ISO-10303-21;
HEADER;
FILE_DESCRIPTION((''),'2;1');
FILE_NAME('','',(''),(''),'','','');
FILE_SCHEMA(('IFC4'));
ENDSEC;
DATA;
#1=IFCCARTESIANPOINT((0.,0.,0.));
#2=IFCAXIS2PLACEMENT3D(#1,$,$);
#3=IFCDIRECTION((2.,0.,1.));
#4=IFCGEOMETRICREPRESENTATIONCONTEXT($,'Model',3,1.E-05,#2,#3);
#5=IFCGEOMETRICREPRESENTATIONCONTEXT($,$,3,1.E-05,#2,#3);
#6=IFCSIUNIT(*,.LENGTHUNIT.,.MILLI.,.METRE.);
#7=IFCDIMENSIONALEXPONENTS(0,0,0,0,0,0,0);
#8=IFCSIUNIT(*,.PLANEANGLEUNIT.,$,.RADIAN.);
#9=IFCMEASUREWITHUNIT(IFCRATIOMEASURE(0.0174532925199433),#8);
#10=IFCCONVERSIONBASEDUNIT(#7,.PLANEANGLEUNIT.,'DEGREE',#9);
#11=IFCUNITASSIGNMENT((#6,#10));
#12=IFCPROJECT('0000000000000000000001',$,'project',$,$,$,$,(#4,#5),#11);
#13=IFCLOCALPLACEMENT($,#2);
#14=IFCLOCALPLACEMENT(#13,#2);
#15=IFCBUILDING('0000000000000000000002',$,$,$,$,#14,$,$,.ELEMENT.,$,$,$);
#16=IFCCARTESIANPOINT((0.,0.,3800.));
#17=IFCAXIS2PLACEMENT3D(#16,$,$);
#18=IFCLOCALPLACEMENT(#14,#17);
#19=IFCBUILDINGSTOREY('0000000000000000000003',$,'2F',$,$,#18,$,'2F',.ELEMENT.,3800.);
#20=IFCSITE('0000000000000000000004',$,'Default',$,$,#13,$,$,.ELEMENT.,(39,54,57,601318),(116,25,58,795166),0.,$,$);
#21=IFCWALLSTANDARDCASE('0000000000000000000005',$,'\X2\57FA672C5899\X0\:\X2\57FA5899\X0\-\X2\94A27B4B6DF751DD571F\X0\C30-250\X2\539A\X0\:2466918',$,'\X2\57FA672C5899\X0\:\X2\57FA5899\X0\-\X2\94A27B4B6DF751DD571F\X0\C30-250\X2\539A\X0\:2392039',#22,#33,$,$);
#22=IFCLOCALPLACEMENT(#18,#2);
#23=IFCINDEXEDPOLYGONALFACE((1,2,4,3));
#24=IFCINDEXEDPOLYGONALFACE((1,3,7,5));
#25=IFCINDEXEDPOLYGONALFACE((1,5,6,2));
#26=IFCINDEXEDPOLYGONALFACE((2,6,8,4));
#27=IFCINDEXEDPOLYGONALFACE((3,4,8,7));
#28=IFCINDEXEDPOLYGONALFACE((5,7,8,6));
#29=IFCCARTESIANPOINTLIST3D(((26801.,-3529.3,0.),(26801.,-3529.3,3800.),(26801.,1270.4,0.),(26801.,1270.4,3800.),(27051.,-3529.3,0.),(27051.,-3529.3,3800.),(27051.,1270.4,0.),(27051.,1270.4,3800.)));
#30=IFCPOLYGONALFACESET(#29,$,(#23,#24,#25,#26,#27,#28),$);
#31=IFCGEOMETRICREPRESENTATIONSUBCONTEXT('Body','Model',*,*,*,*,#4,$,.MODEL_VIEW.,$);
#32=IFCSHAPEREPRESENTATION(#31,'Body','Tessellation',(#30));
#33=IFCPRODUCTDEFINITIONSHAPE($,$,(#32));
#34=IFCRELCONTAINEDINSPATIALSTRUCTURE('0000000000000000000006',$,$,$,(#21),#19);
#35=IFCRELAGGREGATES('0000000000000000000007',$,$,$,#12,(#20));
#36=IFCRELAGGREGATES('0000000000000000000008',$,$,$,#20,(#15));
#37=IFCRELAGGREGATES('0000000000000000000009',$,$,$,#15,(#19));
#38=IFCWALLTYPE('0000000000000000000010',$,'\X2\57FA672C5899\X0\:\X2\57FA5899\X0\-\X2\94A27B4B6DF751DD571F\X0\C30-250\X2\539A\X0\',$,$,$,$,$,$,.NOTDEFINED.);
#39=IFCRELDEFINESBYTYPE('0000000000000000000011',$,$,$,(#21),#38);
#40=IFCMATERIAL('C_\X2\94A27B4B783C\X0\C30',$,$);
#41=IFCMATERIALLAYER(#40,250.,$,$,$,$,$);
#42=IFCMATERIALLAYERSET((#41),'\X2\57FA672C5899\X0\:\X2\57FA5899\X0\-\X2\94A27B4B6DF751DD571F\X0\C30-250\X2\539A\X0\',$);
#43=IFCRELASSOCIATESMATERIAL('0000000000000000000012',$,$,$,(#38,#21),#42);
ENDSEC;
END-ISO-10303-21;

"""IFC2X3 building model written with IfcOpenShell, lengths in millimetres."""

from ifc_helpers import new_model, entity, si_unit, converted_unit, direction, frame, frame_2d, origin, place, context, subcontext, project, spatial, polyline, rectangle, extrude, clip, bounded_halfspace, material, layer, layer_set, layer_usage, type_object, element, save


model = new_model("IFC2X3")

# Units and contexts
model_context = context("Model", 3, precision=1e-05, world=origin(), true_north=direction((2.0, 0.0, 1.0)))
context_of_model = context(None, 3, precision=1e-05, world=origin(), true_north=direction((2.0, 0.0, 1.0)))
body_context = subcontext(model_context, "Body", "Model", "MODEL_VIEW")
ifc_project = project(units=[si_unit("LENGTHUNIT", "METRE", prefix="MILLI"), converted_unit("PLANEANGLEUNIT", "DEGREE", entity("IfcRatioMeasure", 0.0174532925199433), si_unit("PLANEANGLEUNIT", "RADIAN"), dimensions=[0, 0, 0, 0, 0, 0, 0])], contexts=[model_context, context_of_model])

# Site, building, storey
site_placement = place(None, origin())
site = spatial("IfcSite", under=ifc_project, at=site_placement, Name="Default", CompositionType="ELEMENT", RefLatitude=(39, 54, 57, 601318), RefLongitude=(116, 25, 58, 795166), RefElevation=0.0)
building_placement = place(site_placement, origin())
building = spatial("IfcBuilding", under=site, at=building_placement, CompositionType="ELEMENT")
storey_placement = place(building_placement, frame((0.0, 0.0, 3800.0)))
storey = spatial("IfcBuildingStorey", under=building, at=storey_placement, Name="2F", LongName="2F", CompositionType="ELEMENT", Elevation=3800.0)

# Shared definitions
ifc_material_1 = material(Name="C_钢筋砼C30")

# Wall
ifc_layer = layer(ifc_material_1, 250.0)
ifc_layer_set = layer_set([ifc_layer], Name="基本墙:基墙-钢筋混凝土C30-250厚")
wall_type = type_object("IfcWallType", Name="基本墙:基墙-钢筋混凝土C30-250厚", PredefinedType="NOTDEFINED", material=ifc_layer_set)
ifc_layer_usage_1 = layer_usage(ifc_layer_set, "AXIS2", "NEGATIVE", 125.0)
wall_1_placement = place(storey_placement, frame((26926.0, 1270.4, 0.0), z_axis=(0.0, 0.0, 1.0), x_axis=(0.0, -1.0, 0.0)))
element("IfcWallStandardCase", 1, at=wall_1_placement, inside=storey, type_object=wall_type, material=ifc_layer_usage_1, Name="基本墙:基墙-钢筋混凝土C30-250厚:2466918", ObjectType="基本墙:基墙-钢筋混凝土C30-250厚:2392039", context=body_context, shape_type="Clipping", body=[
    clip(clip(clip(extrude(rectangle(XDim=4799.6, YDim=250.0, at=frame_2d((2399.8, 0.0), x_axis=(-1.0, 0.0))), origin(), (0.0, 0.0, 1.0), 3900.0), bounded_halfspace(frame((4799.6, -125.0, 0.0), z_axis=(-1.0, 0.0, 0.0), x_axis=(0.0, 0.0, -1.0)), True, frame((4799.6, -125.0, 0.0), z_axis=(-1.0, 0.0, 0.0), x_axis=(0.0, 0.0, -1.0)), polyline([(0.0, 0.0), (-3800.0, 0.0), (-3800.0, -250.0), (0.0, -250.0), (0.0, 0.0)]))), bounded_halfspace(frame((0.0, 125.0, 0.0), z_axis=(1.0, 0.0, 0.0), x_axis=(0.0, 0.0, -1.0)), True, frame((0.0, 125.0, 0.0), z_axis=(1.0, 0.0, 0.0), x_axis=(0.0, 0.0, -1.0)), polyline([(0.0, 0.0), (-3800.0, 0.0), (-3800.0, -250.0), (0.0, -250.0), (0.0, 0.0)]))), bounded_halfspace(frame((0.0, -125.0, 3800.0), z_axis=(0.0, 0.0, -1.0), x_axis=(-1.0, 0.0, 0.0)), True, frame((0.0, -125.0, 3800.0), z_axis=(0.0, 0.0, -1.0), x_axis=(-1.0, 0.0, 0.0)), polyline([(0.0, 0.0), (0.0, 250.0), (-4799.6, 250.0), (-4799.6, 0.0), (0.0, 0.0)]))),
])

save(model, "model.ifc")
